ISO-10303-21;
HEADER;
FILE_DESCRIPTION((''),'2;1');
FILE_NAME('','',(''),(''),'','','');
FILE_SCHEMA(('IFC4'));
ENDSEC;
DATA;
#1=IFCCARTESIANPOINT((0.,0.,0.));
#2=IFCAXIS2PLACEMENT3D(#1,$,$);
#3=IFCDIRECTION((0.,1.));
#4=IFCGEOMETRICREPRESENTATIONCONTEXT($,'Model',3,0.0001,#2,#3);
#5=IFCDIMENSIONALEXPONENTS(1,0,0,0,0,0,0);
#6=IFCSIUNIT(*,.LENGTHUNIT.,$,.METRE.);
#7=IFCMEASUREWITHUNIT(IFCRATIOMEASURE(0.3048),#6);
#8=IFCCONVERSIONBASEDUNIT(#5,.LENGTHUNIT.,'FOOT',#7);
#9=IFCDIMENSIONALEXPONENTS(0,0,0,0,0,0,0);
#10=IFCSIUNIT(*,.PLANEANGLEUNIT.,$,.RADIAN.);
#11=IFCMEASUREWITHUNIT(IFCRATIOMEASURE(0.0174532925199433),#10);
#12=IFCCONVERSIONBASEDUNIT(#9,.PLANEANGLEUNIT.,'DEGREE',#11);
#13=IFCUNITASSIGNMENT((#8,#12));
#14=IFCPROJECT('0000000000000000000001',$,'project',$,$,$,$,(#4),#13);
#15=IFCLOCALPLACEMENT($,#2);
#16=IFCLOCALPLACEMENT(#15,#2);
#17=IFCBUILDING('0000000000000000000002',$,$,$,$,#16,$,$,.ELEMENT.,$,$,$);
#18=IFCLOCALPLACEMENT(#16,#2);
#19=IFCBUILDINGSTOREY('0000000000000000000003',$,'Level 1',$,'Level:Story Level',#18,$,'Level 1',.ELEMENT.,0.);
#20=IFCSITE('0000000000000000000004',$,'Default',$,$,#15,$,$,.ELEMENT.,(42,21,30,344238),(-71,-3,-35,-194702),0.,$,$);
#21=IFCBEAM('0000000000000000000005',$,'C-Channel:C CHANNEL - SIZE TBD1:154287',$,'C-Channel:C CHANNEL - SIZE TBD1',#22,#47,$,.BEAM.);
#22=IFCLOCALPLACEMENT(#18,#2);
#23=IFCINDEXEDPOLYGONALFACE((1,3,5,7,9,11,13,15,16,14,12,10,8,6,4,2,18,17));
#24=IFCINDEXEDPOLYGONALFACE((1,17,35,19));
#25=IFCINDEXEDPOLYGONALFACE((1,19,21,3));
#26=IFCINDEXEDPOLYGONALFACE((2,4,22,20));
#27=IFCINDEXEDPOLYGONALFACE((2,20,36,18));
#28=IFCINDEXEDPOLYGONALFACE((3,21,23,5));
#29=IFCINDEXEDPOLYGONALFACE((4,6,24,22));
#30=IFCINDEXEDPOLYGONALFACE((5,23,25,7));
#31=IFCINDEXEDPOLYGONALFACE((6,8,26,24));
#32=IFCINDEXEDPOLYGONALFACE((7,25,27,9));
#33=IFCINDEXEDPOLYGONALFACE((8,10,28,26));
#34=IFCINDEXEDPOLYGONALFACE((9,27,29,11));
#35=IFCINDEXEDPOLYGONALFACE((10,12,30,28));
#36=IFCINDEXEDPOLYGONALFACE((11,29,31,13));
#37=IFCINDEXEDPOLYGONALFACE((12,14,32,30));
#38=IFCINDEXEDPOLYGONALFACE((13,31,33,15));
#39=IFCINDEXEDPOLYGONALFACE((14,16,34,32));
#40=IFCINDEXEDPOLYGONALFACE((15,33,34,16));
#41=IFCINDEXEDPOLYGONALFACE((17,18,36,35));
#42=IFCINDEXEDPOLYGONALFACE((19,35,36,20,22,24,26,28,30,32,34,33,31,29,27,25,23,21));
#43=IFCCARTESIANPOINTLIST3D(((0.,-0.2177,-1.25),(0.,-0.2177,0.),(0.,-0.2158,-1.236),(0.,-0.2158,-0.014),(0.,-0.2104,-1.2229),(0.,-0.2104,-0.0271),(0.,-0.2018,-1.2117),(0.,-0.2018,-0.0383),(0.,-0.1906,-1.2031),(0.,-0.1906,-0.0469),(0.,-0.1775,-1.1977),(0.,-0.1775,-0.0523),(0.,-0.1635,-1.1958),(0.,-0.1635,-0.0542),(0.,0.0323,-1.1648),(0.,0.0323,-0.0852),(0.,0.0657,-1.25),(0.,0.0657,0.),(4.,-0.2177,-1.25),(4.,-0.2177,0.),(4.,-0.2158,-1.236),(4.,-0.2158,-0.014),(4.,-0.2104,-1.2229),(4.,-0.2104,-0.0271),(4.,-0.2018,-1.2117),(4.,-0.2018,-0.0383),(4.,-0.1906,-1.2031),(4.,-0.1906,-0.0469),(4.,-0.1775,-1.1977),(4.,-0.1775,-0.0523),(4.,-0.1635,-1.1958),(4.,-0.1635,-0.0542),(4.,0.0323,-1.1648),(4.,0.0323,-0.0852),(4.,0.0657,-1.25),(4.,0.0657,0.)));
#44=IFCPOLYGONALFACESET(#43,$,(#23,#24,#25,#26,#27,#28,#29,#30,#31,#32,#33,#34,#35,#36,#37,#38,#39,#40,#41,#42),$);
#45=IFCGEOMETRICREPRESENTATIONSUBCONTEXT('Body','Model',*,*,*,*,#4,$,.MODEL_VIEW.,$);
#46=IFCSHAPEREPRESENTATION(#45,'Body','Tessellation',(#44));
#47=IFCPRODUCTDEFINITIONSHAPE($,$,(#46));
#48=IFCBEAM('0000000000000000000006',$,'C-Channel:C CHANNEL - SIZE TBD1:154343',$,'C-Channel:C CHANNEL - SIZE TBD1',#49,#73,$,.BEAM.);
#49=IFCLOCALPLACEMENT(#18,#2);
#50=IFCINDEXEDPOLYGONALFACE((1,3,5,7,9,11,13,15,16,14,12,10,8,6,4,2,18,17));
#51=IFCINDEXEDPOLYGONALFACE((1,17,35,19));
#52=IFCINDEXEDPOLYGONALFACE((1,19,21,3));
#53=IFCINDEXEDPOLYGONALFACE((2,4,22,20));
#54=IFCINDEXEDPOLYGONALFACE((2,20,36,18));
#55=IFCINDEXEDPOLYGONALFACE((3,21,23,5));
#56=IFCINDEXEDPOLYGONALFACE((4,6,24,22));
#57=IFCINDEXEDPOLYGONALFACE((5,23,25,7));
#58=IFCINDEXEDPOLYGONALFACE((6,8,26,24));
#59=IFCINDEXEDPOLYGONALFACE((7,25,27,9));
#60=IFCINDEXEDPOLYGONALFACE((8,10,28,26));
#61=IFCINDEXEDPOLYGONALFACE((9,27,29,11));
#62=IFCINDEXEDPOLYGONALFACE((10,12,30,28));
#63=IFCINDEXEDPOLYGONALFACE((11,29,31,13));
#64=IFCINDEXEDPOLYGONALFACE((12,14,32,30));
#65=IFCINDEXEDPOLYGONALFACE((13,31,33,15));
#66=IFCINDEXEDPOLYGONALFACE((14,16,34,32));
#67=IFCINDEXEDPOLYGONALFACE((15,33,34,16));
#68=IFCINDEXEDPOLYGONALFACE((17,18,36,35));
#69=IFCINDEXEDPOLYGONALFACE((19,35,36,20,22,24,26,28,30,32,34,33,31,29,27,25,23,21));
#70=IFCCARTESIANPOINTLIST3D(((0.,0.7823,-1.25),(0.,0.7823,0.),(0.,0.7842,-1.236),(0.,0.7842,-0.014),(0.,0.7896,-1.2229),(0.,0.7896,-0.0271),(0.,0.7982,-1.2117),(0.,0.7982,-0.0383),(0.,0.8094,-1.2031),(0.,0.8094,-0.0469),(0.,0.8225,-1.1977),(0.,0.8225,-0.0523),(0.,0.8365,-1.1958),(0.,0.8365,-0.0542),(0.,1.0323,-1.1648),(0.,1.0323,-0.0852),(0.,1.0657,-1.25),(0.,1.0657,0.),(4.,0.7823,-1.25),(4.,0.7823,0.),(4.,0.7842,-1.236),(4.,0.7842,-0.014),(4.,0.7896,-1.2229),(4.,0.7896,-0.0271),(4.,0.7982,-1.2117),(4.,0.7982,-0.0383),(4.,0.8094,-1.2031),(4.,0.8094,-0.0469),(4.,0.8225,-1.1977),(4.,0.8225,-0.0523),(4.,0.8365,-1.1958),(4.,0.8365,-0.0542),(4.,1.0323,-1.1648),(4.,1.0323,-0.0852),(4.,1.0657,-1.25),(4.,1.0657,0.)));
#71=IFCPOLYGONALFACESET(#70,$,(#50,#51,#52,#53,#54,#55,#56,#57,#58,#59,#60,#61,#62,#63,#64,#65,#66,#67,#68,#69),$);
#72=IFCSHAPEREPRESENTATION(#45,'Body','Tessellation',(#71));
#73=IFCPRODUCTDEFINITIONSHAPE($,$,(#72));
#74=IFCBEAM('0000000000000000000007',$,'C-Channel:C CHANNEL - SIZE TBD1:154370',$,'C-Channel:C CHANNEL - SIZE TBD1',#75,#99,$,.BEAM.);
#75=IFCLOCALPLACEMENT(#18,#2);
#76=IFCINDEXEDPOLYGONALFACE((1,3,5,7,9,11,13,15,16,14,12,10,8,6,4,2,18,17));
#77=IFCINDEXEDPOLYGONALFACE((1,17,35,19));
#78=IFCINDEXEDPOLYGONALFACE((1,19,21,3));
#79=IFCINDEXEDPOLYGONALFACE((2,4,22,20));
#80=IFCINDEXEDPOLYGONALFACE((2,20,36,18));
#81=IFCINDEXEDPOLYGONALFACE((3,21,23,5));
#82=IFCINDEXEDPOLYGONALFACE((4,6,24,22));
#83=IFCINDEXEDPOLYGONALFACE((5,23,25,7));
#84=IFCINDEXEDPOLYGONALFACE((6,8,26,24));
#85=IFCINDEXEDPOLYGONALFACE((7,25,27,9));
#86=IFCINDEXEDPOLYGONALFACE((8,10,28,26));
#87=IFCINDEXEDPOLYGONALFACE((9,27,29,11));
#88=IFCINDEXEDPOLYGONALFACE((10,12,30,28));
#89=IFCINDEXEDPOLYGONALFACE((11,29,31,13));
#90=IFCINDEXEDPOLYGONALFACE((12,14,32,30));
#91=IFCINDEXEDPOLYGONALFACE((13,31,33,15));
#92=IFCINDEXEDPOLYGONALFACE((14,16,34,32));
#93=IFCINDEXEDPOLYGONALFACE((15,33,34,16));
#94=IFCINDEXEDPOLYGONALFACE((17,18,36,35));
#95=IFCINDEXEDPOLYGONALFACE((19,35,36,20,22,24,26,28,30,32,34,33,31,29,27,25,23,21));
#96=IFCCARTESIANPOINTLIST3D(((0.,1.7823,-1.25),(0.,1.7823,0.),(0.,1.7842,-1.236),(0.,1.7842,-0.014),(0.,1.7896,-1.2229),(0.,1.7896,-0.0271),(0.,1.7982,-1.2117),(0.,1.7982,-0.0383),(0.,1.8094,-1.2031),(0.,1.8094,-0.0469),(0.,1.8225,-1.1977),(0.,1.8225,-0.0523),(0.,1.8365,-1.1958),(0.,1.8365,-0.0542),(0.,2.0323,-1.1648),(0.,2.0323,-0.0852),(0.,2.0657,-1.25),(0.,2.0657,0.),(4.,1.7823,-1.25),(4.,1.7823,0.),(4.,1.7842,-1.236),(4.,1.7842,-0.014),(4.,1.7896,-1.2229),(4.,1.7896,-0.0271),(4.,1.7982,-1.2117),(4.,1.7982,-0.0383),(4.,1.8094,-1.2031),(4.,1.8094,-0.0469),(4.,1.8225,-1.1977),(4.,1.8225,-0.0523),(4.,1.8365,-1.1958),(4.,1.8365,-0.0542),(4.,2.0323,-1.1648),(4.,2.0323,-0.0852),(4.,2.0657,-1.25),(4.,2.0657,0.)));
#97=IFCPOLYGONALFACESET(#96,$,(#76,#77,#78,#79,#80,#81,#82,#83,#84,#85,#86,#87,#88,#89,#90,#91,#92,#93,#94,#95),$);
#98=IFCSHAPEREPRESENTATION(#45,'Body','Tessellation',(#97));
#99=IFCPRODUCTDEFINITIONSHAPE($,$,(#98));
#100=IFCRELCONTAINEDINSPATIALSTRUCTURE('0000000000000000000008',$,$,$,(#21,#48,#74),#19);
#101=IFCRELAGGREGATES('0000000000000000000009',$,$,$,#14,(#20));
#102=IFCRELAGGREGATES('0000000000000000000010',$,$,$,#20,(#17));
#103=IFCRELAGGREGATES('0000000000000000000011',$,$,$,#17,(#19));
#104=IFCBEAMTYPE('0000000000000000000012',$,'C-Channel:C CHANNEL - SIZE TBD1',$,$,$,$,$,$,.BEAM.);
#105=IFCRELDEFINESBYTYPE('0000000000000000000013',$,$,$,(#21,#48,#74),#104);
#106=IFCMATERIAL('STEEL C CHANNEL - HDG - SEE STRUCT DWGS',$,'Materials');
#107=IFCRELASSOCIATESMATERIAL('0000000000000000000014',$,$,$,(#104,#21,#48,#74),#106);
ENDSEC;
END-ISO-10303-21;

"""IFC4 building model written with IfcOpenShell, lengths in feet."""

from ifc_helpers import new_model, entity, si_unit, converted_unit, direction, frame, frame_2d, origin, place, context, subcontext, project, spatial, polyline, circle_curve, parameter, trimmed, segment, composite_curve, outline, extrude, source, transform, mapped, material, material_profile, profile_set, profile_usage, type_object, type_shapes, element, save


model = new_model("IFC4")

# Units and contexts
model_context = context("Model", 3, precision=0.0001, world=origin(), true_north=direction((0.0, 1.0)))
body_context = subcontext(model_context, "Body", "Model", "MODEL_VIEW")
ifc_project = project(units=[converted_unit("LENGTHUNIT", "FOOT", entity("IfcRatioMeasure", 0.3048), si_unit("LENGTHUNIT", "METRE"), dimensions=[1, 0, 0, 0, 0, 0, 0]), converted_unit("PLANEANGLEUNIT", "DEGREE", entity("IfcRatioMeasure", 0.0174532925199433), si_unit("PLANEANGLEUNIT", "RADIAN"), dimensions=[0, 0, 0, 0, 0, 0, 0])], contexts=[model_context])

# Site, building, storey
site_placement = place(None, origin())
site = spatial("IfcSite", under=ifc_project, at=site_placement, Name="Default", CompositionType="ELEMENT", RefLatitude=(42, 21, 30, 344238), RefLongitude=(-71, -3, -35, -194702), RefElevation=0.0)
building_placement = place(site_placement, origin())
building = spatial("IfcBuilding", under=site, at=building_placement, CompositionType="ELEMENT")
storey_placement = place(building_placement, origin())
storey = spatial("IfcBuildingStorey", under=building, at=storey_placement, Name="Level 1", ObjectType="Level:Story Level", LongName="Level 1", CompositionType="ELEMENT", Elevation=0.0)

# Beams
ifc_material = material(Name="STEEL C CHANNEL - HDG - SEE STRUCT DWGS", Category="Materials")
ifc_material_profile = material_profile(ifc_material, outline(composite_curve([segment(polyline([(-0.1469, -0.625), (0.1365, -0.625)]), True, "CONTINUOUS"), segment(polyline([(0.1365, -0.625), (0.1365, 0.625)]), True, "CONTINUOUS"), segment(polyline([(0.1365, 0.625), (-0.1469, 0.625)]), True, "CONTINUOUS"), segment(trimmed(circle_curve(frame_2d((-0.0927, 0.625), x_axis=(-1.0, 0.0)), 0.0542), [parameter(0.0)], [parameter(90.0)], True, "PARAMETER"), True, "CONTINUOUS"), segment(polyline([(-0.0927, 0.5708), (0.1031, 0.5398)]), True, "CONTINUOUS"), segment(polyline([(0.1031, 0.5398), (0.1031, -0.5398)]), True, "CONTINUOUS"), segment(polyline([(0.1031, -0.5398), (-0.0927, -0.5708)]), True, "CONTINUOUS"), segment(trimmed(circle_curve(frame_2d((-0.0927, -0.625), x_axis=(0.0, 1.0)), 0.0542), [parameter(0.0)], [parameter(90.0)], True, "PARAMETER"), True, "CONTINUOUS")], self_intersect=False)), Name="C CHANNEL - SIZE TBD1")
ifc_profile_set = profile_set([ifc_material_profile], Name="C CHANNEL - SIZE TBD1")
ifc_profile_usage_1 = profile_usage(ifc_profile_set, cardinal=8)
beam_type = type_object("IfcBeamType", Name="C-Channel:C CHANNEL - SIZE TBD1", PredefinedType="BEAM", material=ifc_profile_set)
shared_shape = source(origin(), body_context, "Body", "SweptSolid", [
    extrude(outline(composite_curve([segment(polyline([(-0.1469, -0.625), (0.1365, -0.625)]), True, "CONTINUOUS"), segment(polyline([(0.1365, -0.625), (0.1365, 0.625)]), True, "CONTINUOUS"), segment(polyline([(0.1365, 0.625), (-0.1469, 0.625)]), True, "CONTINUOUS"), segment(trimmed(circle_curve(frame_2d((-0.0927, 0.625), x_axis=(-1.0, 0.0)), 0.0542), [parameter(0.0)], [parameter(90.0)], True, "PARAMETER"), True, "CONTINUOUS"), segment(polyline([(-0.0927, 0.5708), (0.1031, 0.5398)]), True, "CONTINUOUS"), segment(polyline([(0.1031, 0.5398), (0.1031, -0.5398)]), True, "CONTINUOUS"), segment(polyline([(0.1031, -0.5398), (-0.0927, -0.5708)]), True, "CONTINUOUS"), segment(trimmed(circle_curve(frame_2d((-0.0927, -0.625), x_axis=(0.0, 1.0)), 0.0542), [parameter(0.0)], [parameter(90.0)], True, "PARAMETER"), True, "CONTINUOUS")], self_intersect=False)), frame((-2.0, -0.0708, 0.0), z_axis=(1.0, 0.0, 0.0), x_axis=(0.0, 1.0, 0.0)), (0.0, 0.0, 1.0), 4.0),
])
type_shapes(beam_type, [shared_shape])
beam_1_placement = place(storey_placement, frame((2.0, 0.0, -0.625)))
element("IfcBeam", 1, at=beam_1_placement, inside=storey, type_object=beam_type, material=ifc_profile_usage_1, Name="C-Channel:C CHANNEL - SIZE TBD1:154287", ObjectType="C-Channel:C CHANNEL - SIZE TBD1", PredefinedType="BEAM", context=body_context, shape_type="MappedRepresentation", body=[
    mapped(shared_shape, transform((0.0, 0.0, 0.0), scale=1.0)),
])
ifc_profile_usage_2 = profile_usage(ifc_profile_set, cardinal=8)
beam_2_placement = place(storey_placement, frame((2.0, 1.0, -0.625)))
element("IfcBeam", 2, at=beam_2_placement, inside=storey, type_object=beam_type, material=ifc_profile_usage_2, Name="C-Channel:C CHANNEL - SIZE TBD1:154343", ObjectType="C-Channel:C CHANNEL - SIZE TBD1", PredefinedType="BEAM", context=body_context, shape_type="MappedRepresentation", body=[
    mapped(shared_shape, transform((0.0, 0.0, 0.0), scale=1.0)),
])
ifc_profile_usage_3 = profile_usage(ifc_profile_set, cardinal=8)
beam_3_placement = place(storey_placement, frame((2.0, 2.0, -0.625)))
element("IfcBeam", 3, at=beam_3_placement, inside=storey, type_object=beam_type, material=ifc_profile_usage_3, Name="C-Channel:C CHANNEL - SIZE TBD1:154370", ObjectType="C-Channel:C CHANNEL - SIZE TBD1", PredefinedType="BEAM", context=body_context, shape_type="MappedRepresentation", body=[
    mapped(shared_shape, transform((0.0, 0.0, 0.0), scale=1.0)),
])

save(model, "model.ifc")
